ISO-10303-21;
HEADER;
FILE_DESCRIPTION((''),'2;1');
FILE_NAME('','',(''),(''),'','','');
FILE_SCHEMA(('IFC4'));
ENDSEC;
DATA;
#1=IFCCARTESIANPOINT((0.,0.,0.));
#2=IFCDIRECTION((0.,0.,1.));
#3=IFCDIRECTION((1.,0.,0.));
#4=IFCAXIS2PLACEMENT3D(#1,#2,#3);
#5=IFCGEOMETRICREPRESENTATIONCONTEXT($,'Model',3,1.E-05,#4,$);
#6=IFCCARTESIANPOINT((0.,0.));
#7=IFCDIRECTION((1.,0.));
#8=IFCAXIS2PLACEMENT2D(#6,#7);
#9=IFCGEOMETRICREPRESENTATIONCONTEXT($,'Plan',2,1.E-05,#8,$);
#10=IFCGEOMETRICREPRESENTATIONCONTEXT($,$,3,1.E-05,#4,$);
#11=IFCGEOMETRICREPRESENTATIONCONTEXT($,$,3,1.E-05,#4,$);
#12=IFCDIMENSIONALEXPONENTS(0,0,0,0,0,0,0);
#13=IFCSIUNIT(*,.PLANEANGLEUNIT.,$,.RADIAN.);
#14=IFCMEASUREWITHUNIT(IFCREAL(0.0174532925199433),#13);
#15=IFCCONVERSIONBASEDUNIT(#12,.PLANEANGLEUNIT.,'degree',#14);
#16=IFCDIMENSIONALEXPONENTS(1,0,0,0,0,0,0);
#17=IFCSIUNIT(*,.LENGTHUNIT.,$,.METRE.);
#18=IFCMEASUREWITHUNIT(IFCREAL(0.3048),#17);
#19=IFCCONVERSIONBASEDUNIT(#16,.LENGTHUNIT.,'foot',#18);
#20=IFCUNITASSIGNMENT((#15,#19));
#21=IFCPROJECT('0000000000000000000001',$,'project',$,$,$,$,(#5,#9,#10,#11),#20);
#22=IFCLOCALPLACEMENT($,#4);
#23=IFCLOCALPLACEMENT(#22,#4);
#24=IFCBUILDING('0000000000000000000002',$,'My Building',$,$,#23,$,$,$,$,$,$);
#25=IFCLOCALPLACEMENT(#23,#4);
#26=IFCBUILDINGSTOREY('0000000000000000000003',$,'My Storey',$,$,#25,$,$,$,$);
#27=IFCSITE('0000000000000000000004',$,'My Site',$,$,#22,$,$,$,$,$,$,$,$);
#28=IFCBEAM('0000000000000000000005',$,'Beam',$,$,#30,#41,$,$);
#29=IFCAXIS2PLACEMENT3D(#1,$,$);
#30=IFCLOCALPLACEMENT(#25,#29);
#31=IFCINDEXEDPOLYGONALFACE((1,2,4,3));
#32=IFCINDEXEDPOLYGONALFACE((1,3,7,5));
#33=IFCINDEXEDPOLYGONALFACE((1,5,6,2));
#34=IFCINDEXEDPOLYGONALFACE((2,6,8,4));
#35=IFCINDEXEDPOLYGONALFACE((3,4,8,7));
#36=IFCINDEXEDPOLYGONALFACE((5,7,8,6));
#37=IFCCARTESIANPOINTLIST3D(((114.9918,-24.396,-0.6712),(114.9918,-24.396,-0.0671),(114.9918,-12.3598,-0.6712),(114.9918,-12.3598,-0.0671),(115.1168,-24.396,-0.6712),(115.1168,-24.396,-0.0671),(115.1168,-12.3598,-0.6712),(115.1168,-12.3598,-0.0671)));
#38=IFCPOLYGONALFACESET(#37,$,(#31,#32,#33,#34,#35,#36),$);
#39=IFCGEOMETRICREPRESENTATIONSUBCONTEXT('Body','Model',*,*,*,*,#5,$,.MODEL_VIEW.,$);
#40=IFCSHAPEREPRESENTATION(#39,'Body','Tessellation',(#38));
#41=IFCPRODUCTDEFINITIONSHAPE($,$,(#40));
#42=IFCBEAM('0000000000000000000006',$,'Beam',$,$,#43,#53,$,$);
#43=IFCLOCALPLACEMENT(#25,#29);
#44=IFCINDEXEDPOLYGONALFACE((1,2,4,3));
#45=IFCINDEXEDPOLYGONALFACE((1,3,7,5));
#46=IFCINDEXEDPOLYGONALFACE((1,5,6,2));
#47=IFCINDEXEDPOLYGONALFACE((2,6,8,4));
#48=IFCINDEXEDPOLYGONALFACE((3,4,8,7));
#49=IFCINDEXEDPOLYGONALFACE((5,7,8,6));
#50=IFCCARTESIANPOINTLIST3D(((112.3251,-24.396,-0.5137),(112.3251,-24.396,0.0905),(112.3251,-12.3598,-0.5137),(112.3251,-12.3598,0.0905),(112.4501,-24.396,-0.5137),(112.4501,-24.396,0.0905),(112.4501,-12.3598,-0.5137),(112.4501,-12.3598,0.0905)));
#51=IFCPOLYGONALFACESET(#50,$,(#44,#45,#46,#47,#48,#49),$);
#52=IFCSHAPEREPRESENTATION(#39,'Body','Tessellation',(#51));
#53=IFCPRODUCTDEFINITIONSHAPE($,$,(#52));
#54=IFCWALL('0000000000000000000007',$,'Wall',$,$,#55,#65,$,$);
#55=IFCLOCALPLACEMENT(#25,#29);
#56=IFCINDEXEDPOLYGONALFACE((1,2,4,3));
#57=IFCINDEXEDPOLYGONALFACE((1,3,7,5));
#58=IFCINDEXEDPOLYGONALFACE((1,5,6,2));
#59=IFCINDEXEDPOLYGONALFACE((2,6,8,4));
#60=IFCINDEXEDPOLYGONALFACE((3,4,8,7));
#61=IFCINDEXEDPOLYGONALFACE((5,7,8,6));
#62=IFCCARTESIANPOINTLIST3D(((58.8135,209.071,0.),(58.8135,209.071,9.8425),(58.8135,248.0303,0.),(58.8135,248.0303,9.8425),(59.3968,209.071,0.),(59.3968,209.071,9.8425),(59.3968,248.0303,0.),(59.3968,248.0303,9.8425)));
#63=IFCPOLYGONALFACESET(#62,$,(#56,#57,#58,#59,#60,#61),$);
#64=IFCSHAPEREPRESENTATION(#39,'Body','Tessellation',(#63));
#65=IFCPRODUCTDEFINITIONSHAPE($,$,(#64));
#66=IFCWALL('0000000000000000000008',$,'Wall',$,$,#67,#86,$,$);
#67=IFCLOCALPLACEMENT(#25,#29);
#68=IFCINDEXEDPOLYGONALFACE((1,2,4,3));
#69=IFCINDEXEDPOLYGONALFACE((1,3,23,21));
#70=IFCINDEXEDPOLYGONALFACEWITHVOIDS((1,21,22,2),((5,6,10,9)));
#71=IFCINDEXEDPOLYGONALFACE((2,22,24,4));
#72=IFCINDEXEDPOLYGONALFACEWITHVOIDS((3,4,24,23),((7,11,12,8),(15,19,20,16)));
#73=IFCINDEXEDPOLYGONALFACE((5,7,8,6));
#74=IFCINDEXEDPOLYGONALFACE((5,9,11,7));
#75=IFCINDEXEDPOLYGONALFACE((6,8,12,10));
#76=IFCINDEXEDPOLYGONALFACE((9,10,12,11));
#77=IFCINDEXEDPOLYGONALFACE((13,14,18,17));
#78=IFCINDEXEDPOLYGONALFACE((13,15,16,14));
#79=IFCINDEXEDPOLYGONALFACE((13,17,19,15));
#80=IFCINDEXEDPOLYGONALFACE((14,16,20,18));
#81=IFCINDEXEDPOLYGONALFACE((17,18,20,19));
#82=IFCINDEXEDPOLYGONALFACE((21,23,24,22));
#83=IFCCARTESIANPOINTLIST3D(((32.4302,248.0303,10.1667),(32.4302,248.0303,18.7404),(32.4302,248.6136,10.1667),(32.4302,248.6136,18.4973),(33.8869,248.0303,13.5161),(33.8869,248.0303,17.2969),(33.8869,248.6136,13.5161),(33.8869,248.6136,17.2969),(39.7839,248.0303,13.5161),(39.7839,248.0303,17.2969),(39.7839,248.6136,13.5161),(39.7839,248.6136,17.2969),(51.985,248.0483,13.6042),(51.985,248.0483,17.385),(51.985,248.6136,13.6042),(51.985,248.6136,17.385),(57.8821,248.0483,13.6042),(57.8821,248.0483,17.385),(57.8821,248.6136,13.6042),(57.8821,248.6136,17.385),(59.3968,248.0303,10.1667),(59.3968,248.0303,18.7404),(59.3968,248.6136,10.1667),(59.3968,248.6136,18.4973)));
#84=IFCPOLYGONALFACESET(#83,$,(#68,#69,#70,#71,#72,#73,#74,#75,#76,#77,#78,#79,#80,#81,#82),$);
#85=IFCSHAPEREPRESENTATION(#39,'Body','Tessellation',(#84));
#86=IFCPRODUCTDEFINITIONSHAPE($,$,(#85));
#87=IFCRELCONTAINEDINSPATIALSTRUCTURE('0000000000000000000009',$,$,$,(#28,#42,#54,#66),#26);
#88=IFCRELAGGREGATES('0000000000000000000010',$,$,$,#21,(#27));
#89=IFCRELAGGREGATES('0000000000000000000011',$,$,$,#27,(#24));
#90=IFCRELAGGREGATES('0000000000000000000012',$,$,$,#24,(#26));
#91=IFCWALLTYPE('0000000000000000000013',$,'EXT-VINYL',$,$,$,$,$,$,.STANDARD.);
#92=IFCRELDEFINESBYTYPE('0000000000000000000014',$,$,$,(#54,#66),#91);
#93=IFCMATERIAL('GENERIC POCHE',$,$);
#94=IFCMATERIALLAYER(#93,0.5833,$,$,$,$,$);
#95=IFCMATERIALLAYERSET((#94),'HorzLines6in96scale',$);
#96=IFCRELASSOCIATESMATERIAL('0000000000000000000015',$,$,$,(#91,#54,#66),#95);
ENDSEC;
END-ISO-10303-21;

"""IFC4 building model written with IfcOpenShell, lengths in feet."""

from ifc_helpers import new_model, entity, si_unit, converted_unit, frame, origin_with_axes, origin_2d_with_axis, place, context, subcontext, project, spatial, line, indexed_curve, rectangle, outline, extrude, clip, halfspace, source, transform, mapped, material, layer, layer_set, layer_usage, type_object, element, save


model = new_model("IFC4")

# Units and contexts
model_context = context("Model", 3, precision=1e-05, world=origin_with_axes())
plan_context = context("Plan", 2, precision=1e-05, world=origin_2d_with_axis())
context_of_model_1 = context(None, 3, precision=1e-05, world=origin_with_axes())
context_of_model_2 = context(None, 3, precision=1e-05, world=origin_with_axes())
body_context = subcontext(model_context, "Body", "Model", "MODEL_VIEW")
ifc_project = project(units=[converted_unit("PLANEANGLEUNIT", "degree", entity("IfcReal", 0.0174532925199433), si_unit("PLANEANGLEUNIT", "RADIAN"), dimensions=[0, 0, 0, 0, 0, 0, 0]), converted_unit("LENGTHUNIT", "foot", entity("IfcReal", 0.3048), si_unit("LENGTHUNIT", "METRE"), dimensions=[1, 0, 0, 0, 0, 0, 0])], contexts=[model_context, plan_context, context_of_model_1, context_of_model_2])

# Site, building, storey
site_placement = place(None, origin_with_axes())
site = spatial("IfcSite", under=ifc_project, at=site_placement, Name="My Site")
building_placement = place(site_placement, origin_with_axes())
building = spatial("IfcBuilding", under=site, at=building_placement, Name="My Building")
storey_placement = place(building_placement, origin_with_axes())
storey = spatial("IfcBuildingStorey", under=building, at=storey_placement, Name="My Storey")

# Beams
beam_1_placement = place(storey_placement, frame((115.0543, -24.396, -0.3692), z_axis=(0.0, 1.0, 0.0), x_axis=(-1.0, 0.0, 0.0)))
element("IfcBeam", 1, at=beam_1_placement, inside=storey, Name="Beam", context=body_context, shape_type="SweptSolid", body=[
    extrude(rectangle(XDim=0.125, YDim=0.6042), origin_with_axes(), (0.0, 0.0, 1.0), 12.0362),
])
beam_2_placement = place(storey_placement, frame((112.3876, -24.396, -0.2116), z_axis=(0.0, 1.0, 0.0), x_axis=(-1.0, 0.0, 0.0)))
element("IfcBeam", 2, at=beam_2_placement, inside=storey, Name="Beam", context=body_context, shape_type="SweptSolid", body=[
    extrude(rectangle(XDim=0.125, YDim=0.6042), origin_with_axes(), (0.0, 0.0, 1.0), 12.0362),
])

# Wall
ifc_material_1 = material(Name="GENERIC POCHE")
ifc_layer_1 = layer(ifc_material_1, 0.5833)
ifc_layer_set_1 = layer_set([ifc_layer_1], Name="HorzLines6in96scale")
ifc_layer_usage_1 = layer_usage(ifc_layer_set_1, "AXIS2", "POSITIVE", 0.0)
wall_type = type_object("IfcWallType", Name="EXT-VINYL", PredefinedType="STANDARD", material=ifc_layer_set_1)
wall_1_placement = place(storey_placement, frame((58.8135, 248.0303, 0.0), z_axis=(0.0, 0.0, 1.0), x_axis=(0.0, -1.0, 0.0)))
element("IfcWall", 3, at=wall_1_placement, inside=storey, type_object=wall_type, material=ifc_layer_usage_1, Name="Wall", context=body_context, shape_type="SweptSolid", body=[
    extrude(outline(indexed_curve([(0.0, 0.0), (0.0, 0.5833), (38.9593, 0.5833), (38.9593, 0.0), (0.0, 0.0)], self_intersect=False)), origin_with_axes(), (0.0, 0.0, 1.0), 9.8425),
])

# Wall, openings
ifc_layer_usage_2 = layer_usage(ifc_layer_set_1, "AXIS2", "POSITIVE", 0.0)
wall_2_placement = place(storey_placement, frame((59.3968, 248.6136, 10.1667), z_axis=(0.0, 0.0, 1.0), x_axis=(-1.0, 0.0, 0.0)))
wall_2 = element("IfcWall", 4, at=wall_2_placement, inside=storey, type_object=wall_type, material=ifc_layer_usage_2, Name="Wall", context=body_context, shape_type="Clipping", body=[
    clip(extrude(outline(indexed_curve([(0.0, 0.0), (0.0, 0.5833), (26.9666, 0.5833), (26.9666, 0.0), (0.0, 0.0)], self_intersect=False)), origin_with_axes(), (0.0, 0.0, 1.0), 18.7404), halfspace(frame((0.0, 0.5833, 8.5737), z_axis=(0.0, -0.384618, 0.923076), x_axis=(1.0, 0.000001, 0.0)), False)),
])
shared_shape_1 = source(origin_with_axes(), body_context, "Body", "SweptSolid", [
    extrude(outline(indexed_curve([(0.0, 0.0), (5.897, 0.0), (5.897, 3.7808), (0.0, 3.7808)], segments=[line(1, 2), line(2, 3), line(3, 4), line(4, 1)])), frame((0.0, -0.3281, 0.0), z_axis=(0.0, -1.0, 0.0), x_axis=(1.0, 0.0, 0.0)), (0.0, 0.0, -1.0), 1.052),
])
opening_1_placement = place(wall_2_placement, frame((7.4118, 0.2372, 3.4375), z_axis=(0.0, 0.0, 1.0), x_axis=(-1.0, 0.0, 0.0)))
element("IfcOpeningElement", 5, at=opening_1_placement, cuts=wall_2, PredefinedType="OPENING", context=body_context, shape_type="MappedRepresentation", body=[
    mapped(shared_shape_1, transform((0.0, 0.0, 0.0), x_axis=(1.0, 0.0, 0.0), y_axis=(0.0, 1.0, 0.0), z_axis=(0.0, 0.0, 1.0), scale=1.0)),
])
opening_2_placement = place(wall_2_placement, frame((19.6129, 0.2372, 3.3494), z_axis=(0.0, 0.0, 1.0), x_axis=(1.0, 0.0, 0.0)))
element("IfcOpeningElement", 6, at=opening_2_placement, cuts=wall_2, PredefinedType="OPENING", context=body_context, shape_type="MappedRepresentation", body=[
    mapped(shared_shape_1, transform((0.0, 0.0, 0.0), x_axis=(1.0, 0.0, 0.0), y_axis=(0.0, 1.0, 0.0), z_axis=(0.0, 0.0, 1.0), scale=1.0)),
])

save(model, "model.ifc")
